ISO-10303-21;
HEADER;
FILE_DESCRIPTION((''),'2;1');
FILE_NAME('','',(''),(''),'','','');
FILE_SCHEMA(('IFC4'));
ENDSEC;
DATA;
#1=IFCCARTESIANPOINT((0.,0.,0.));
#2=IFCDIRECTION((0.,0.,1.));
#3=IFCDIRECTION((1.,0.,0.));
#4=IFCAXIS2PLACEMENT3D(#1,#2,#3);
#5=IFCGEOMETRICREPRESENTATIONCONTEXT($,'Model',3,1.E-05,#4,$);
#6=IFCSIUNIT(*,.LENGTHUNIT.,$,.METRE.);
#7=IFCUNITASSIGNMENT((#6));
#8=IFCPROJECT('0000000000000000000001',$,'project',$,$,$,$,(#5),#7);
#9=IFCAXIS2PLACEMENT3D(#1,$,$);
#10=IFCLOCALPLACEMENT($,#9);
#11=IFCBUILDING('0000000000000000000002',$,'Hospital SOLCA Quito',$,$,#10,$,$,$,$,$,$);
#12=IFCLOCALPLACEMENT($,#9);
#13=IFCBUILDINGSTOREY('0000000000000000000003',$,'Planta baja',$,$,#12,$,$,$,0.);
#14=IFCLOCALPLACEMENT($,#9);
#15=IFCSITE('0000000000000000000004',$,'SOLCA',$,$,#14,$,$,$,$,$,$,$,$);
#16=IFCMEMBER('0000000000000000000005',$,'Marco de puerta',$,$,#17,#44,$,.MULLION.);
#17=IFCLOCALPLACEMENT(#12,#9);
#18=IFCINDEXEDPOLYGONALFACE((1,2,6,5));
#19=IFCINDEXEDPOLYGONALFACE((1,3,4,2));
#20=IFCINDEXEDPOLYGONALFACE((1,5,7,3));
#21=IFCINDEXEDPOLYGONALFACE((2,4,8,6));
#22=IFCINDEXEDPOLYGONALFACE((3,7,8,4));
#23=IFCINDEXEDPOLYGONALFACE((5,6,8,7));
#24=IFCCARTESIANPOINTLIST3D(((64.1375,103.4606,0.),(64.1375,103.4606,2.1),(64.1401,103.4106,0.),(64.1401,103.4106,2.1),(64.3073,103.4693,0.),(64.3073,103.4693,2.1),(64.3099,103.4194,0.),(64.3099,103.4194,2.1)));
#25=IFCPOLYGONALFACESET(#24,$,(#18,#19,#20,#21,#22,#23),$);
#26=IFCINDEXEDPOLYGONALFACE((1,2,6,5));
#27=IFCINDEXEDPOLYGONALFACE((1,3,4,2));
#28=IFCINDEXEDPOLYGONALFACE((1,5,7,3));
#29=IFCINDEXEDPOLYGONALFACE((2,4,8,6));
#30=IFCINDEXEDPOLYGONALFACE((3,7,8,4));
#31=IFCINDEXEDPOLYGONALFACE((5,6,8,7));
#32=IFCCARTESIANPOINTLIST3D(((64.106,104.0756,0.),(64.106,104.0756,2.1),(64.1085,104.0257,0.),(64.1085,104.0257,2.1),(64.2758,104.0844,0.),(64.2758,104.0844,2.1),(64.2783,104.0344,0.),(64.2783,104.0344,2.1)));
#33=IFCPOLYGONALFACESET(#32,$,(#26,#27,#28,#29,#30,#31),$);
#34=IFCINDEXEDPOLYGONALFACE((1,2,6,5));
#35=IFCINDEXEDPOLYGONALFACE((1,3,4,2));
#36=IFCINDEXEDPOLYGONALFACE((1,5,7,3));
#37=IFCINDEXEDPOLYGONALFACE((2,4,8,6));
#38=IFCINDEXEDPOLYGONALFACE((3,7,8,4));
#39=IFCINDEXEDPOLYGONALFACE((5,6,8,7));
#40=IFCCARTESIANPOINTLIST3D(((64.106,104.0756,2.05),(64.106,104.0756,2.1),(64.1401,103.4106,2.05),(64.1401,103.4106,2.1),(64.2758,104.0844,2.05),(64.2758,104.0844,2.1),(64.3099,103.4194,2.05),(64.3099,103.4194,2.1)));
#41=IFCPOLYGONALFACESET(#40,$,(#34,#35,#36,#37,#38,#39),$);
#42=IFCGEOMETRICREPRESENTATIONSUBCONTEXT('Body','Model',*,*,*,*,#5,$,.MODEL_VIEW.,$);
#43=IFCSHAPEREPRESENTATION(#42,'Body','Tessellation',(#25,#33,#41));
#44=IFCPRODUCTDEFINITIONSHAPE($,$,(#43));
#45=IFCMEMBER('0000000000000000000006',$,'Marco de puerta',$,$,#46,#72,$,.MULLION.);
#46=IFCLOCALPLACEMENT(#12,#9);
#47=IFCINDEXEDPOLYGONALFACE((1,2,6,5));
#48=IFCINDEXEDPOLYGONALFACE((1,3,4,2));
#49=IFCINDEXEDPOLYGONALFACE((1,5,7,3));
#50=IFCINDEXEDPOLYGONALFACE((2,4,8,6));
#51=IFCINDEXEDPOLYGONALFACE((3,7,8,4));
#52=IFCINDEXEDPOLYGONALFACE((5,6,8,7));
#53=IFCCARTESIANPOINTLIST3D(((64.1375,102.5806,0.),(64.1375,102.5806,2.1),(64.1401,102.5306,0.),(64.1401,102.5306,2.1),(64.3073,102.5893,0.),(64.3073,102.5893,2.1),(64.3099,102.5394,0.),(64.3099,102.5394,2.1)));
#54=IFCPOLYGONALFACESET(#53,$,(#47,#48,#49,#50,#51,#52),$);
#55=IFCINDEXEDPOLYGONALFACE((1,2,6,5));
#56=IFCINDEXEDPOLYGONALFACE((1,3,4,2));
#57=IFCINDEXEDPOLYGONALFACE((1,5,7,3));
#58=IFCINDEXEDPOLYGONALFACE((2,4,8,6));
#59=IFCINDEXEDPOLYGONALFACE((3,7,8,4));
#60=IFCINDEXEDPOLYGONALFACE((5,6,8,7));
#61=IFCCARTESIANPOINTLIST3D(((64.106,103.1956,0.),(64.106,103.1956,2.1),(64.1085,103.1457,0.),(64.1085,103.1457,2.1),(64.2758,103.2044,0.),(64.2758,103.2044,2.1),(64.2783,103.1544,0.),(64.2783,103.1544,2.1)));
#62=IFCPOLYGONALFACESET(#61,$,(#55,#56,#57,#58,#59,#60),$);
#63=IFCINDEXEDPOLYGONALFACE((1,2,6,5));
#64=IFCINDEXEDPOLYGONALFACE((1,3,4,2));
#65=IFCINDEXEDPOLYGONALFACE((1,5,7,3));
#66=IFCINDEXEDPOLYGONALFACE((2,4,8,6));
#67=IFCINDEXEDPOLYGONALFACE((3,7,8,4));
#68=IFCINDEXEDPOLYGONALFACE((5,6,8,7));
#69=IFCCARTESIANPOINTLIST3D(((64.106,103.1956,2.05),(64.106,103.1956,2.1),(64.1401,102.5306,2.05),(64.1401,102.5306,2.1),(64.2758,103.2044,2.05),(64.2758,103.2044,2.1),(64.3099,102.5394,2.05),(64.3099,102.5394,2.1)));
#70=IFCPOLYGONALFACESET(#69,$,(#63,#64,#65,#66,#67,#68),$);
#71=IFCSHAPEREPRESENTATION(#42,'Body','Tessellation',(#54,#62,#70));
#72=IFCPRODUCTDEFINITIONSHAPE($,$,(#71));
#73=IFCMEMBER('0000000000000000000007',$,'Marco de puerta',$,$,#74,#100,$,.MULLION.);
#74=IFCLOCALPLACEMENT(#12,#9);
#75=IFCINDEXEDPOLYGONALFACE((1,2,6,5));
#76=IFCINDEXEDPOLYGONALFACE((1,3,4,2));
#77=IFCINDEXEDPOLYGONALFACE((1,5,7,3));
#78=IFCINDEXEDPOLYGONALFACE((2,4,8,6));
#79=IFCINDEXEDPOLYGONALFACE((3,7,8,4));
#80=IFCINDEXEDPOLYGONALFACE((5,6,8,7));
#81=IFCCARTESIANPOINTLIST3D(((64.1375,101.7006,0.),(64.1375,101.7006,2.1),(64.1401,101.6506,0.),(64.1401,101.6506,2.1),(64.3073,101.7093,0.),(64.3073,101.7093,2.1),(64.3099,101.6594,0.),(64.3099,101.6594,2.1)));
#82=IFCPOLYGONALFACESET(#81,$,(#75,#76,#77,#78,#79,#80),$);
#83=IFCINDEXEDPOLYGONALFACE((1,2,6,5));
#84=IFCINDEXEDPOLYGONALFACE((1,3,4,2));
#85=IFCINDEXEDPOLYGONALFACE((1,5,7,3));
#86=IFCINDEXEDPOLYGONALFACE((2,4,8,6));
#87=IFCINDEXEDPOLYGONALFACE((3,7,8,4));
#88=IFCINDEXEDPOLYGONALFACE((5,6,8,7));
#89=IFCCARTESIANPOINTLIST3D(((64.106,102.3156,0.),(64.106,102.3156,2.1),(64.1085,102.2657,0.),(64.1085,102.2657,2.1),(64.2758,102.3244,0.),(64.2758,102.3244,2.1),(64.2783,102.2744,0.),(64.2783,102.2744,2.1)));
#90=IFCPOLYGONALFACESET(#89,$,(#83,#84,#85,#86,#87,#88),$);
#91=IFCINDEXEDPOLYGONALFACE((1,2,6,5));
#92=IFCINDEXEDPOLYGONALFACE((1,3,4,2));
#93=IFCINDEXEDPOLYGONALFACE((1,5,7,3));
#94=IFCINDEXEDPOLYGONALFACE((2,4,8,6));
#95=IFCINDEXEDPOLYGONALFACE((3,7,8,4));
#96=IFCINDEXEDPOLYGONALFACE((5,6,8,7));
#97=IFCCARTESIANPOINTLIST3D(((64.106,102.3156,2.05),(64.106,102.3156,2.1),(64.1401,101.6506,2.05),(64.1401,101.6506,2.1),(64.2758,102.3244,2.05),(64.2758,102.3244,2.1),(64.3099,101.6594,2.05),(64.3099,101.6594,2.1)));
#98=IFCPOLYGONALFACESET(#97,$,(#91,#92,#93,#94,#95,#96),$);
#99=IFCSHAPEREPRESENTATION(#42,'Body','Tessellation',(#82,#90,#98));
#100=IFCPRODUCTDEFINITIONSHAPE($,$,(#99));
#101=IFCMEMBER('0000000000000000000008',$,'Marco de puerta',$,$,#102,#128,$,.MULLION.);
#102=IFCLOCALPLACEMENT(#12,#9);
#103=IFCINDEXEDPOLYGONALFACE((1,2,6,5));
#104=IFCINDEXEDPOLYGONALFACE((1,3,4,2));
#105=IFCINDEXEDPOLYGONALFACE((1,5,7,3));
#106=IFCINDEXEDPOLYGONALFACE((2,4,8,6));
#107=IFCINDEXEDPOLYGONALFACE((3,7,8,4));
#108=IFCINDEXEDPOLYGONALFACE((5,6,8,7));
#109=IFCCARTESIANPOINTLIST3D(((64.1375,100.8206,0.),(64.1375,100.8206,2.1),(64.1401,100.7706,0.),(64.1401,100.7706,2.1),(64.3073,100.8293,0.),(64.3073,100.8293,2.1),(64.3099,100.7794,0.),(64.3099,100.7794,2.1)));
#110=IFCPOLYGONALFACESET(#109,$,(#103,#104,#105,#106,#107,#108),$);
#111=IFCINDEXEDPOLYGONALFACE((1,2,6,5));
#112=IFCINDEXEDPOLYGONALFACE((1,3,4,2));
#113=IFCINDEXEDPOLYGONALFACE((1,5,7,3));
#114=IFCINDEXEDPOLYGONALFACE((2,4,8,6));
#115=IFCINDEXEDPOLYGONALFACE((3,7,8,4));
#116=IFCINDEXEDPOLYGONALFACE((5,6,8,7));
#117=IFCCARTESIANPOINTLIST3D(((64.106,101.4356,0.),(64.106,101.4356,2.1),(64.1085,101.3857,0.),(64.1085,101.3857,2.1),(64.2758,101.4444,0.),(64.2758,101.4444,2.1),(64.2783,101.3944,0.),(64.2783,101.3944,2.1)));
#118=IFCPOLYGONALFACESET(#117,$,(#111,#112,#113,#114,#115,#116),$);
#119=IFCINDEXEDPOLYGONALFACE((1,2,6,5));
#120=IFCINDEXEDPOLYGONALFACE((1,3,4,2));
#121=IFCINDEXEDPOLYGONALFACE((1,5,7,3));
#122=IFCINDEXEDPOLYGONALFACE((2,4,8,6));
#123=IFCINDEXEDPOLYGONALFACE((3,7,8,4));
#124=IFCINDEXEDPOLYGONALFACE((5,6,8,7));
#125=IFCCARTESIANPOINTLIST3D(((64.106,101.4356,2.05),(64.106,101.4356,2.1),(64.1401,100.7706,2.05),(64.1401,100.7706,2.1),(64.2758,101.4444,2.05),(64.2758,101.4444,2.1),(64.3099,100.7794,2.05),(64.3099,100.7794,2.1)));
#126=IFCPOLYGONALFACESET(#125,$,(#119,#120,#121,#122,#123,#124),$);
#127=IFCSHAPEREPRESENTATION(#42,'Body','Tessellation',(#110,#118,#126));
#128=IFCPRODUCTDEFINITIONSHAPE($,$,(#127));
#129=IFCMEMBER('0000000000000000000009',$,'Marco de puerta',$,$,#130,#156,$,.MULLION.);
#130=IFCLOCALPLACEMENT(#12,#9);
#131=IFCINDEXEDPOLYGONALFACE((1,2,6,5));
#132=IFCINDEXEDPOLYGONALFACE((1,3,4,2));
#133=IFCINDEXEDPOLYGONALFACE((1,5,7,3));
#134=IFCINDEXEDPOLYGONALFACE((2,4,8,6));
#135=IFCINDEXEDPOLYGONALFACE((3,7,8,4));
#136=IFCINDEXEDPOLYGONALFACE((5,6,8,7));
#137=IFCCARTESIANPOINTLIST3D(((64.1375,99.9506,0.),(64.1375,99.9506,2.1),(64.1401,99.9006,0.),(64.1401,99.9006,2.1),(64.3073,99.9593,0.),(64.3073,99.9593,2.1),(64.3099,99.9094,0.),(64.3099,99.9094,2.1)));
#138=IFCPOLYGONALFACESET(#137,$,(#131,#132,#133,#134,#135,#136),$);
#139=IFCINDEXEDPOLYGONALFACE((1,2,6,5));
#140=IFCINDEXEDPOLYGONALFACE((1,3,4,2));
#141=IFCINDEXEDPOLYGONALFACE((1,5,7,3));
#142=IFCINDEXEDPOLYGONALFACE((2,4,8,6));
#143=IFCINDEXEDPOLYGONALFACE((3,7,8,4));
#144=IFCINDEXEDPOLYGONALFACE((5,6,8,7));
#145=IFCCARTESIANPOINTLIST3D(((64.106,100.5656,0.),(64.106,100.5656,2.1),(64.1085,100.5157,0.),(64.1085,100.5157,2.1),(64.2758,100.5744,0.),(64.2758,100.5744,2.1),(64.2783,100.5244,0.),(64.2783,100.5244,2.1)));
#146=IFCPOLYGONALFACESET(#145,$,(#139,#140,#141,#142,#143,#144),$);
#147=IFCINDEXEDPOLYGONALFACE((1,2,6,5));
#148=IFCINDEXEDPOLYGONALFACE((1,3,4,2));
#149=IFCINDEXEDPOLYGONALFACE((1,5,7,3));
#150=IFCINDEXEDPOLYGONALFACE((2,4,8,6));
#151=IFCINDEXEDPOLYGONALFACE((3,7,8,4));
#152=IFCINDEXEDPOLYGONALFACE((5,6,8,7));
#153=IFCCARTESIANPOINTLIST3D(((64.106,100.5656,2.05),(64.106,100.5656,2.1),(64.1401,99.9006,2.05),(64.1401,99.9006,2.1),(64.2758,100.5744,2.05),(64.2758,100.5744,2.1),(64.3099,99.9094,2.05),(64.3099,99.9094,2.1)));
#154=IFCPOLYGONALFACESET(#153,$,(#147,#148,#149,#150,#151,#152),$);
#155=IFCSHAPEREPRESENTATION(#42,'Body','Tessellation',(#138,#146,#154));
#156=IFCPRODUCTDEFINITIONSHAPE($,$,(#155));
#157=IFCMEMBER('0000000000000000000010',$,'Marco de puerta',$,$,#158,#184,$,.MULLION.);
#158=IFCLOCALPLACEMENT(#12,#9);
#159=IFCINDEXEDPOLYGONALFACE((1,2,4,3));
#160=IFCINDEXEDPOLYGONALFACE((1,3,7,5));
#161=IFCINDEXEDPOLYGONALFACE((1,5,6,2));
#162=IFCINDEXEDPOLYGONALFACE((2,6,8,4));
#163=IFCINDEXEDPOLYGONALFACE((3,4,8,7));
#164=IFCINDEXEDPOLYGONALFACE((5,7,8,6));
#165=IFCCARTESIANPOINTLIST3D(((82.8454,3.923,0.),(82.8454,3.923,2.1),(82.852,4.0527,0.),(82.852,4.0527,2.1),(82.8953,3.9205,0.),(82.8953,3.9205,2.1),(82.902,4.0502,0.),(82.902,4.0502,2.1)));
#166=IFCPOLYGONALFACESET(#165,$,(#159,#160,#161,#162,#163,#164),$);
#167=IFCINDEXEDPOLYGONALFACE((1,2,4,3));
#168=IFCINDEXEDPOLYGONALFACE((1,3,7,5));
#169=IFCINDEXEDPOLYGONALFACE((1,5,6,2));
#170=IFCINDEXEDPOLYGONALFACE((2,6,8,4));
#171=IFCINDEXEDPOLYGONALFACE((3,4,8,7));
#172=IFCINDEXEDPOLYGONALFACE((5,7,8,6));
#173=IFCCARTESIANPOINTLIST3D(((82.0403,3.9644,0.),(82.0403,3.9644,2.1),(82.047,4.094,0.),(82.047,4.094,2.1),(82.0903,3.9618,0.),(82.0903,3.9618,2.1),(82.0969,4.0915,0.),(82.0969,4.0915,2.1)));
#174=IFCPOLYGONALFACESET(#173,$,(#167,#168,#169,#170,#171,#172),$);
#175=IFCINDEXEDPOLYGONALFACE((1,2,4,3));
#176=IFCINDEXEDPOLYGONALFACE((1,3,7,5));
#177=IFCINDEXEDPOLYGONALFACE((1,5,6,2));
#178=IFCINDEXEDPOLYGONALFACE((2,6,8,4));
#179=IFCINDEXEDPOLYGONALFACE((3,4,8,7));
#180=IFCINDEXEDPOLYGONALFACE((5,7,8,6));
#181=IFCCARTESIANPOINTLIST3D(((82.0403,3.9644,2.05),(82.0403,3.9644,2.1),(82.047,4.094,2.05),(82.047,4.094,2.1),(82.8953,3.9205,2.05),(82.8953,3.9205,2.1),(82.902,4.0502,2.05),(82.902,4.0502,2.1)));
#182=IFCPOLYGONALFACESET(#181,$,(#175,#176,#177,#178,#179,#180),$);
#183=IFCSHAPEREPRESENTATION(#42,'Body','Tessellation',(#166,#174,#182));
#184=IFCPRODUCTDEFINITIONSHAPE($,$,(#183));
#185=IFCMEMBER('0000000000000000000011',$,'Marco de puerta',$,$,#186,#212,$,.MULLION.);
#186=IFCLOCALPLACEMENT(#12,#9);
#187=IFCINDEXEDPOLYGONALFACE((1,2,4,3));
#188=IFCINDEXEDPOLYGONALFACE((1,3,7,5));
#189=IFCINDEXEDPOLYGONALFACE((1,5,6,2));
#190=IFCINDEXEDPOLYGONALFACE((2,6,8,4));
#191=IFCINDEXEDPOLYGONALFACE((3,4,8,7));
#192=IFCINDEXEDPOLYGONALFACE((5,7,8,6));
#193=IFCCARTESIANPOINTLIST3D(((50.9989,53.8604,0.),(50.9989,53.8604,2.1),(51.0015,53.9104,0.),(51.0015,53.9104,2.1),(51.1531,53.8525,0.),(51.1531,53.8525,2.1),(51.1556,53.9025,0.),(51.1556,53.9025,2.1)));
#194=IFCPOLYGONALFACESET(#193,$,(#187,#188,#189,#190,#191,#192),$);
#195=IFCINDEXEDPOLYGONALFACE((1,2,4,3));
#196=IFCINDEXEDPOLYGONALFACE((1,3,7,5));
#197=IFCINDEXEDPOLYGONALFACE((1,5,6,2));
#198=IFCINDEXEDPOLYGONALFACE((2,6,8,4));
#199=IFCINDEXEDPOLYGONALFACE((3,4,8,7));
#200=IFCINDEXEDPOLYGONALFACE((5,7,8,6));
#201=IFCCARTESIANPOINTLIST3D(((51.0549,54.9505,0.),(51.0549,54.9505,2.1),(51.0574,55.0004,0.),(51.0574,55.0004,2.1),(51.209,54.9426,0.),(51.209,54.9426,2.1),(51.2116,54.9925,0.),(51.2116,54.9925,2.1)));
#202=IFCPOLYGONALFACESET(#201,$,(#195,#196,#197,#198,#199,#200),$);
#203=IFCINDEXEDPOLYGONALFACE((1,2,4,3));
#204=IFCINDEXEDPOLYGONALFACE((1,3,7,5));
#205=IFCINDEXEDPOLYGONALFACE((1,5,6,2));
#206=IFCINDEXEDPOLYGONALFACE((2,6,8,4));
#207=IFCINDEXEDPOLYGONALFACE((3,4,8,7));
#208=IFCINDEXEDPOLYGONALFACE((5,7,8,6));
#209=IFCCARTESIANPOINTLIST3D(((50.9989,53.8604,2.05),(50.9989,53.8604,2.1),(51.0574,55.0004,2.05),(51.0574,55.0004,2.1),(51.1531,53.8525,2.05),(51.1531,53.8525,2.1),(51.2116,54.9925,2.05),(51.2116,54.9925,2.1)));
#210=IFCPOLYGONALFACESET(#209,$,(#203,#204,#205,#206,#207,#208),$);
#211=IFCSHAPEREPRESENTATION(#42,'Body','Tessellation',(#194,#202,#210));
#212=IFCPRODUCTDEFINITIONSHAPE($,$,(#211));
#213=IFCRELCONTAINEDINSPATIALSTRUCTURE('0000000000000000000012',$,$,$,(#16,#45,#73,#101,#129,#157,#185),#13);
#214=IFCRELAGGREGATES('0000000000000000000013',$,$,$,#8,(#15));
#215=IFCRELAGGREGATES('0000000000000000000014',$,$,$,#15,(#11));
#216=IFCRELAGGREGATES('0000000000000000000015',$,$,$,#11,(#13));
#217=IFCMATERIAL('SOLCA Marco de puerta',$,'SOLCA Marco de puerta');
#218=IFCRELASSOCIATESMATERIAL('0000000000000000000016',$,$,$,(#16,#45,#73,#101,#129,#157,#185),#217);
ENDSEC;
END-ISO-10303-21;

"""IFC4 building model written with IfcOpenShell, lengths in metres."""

from ifc_helpers import new_model, si_unit, frame, origin, origin_with_axes, place, context, subcontext, project, spatial, polyline, outline, extrude, material, element, save


model = new_model("IFC4")

# Units and contexts
model_context = context("Model", 3, precision=1e-05, world=origin_with_axes())
body_context = subcontext(model_context, "Body", "Model", "MODEL_VIEW")
ifc_project = project(units=[si_unit("LENGTHUNIT", "METRE")], contexts=[model_context])

# Site, building, storey
site_placement = place(None, origin())
site = spatial("IfcSite", under=ifc_project, at=site_placement, Name="SOLCA")
building_placement = place(None, origin())
building = spatial("IfcBuilding", under=site, at=building_placement, Name="Hospital SOLCA Quito")
storey_placement = place(None, origin())
storey = spatial("IfcBuildingStorey", under=building, at=storey_placement, Name="Planta baja", Elevation=0.0)

# Members
ifc_material_1 = material(Name="SOLCA Marco de puerta", Category="SOLCA Marco de puerta")
member_1_placement = place(storey_placement, origin_with_axes())
element("IfcMember", 1, at=member_1_placement, inside=storey, material=ifc_material_1, Name="Marco de puerta", PredefinedType="MULLION", context=body_context, shape_type="SweptSolid", body=[
    extrude(outline(polyline([(64.3099, 103.4194), (64.3073, 103.4693), (64.1375, 103.4606), (64.1401, 103.4106), (64.3099, 103.4194)])), origin_with_axes(), (0.0, 0.0, 1.0), 2.1),
    extrude(outline(polyline([(64.2783, 104.0344), (64.2758, 104.0844), (64.106, 104.0756), (64.1085, 104.0257), (64.2783, 104.0344)])), origin_with_axes(), (0.0, 0.0, 1.0), 2.1),
    extrude(outline(polyline([(64.3099, 103.4194), (64.2758, 104.0844), (64.106, 104.0756), (64.1401, 103.4106), (64.3099, 103.4194)])), frame((0.0, 0.0, 2.05), z_axis=(0.0, 0.0, 1.0), x_axis=(1.0, 0.0, 0.0)), (0.0, 0.0, 1.0), 0.05),
])
member_2_placement = place(storey_placement, origin_with_axes())
element("IfcMember", 2, at=member_2_placement, inside=storey, material=ifc_material_1, Name="Marco de puerta", PredefinedType="MULLION", context=body_context, shape_type="SweptSolid", body=[
    extrude(outline(polyline([(64.3099, 102.5394), (64.3073, 102.5893), (64.1375, 102.5806), (64.1401, 102.5306), (64.3099, 102.5394)])), origin_with_axes(), (0.0, 0.0, 1.0), 2.1),
    extrude(outline(polyline([(64.2783, 103.1544), (64.2758, 103.2044), (64.106, 103.1956), (64.1085, 103.1457), (64.2783, 103.1544)])), origin_with_axes(), (0.0, 0.0, 1.0), 2.1),
    extrude(outline(polyline([(64.3099, 102.5394), (64.2758, 103.2044), (64.106, 103.1956), (64.1401, 102.5306), (64.3099, 102.5394)])), frame((0.0, 0.0, 2.05), z_axis=(0.0, 0.0, 1.0), x_axis=(1.0, 0.0, 0.0)), (0.0, 0.0, 1.0), 0.05),
])
member_3_placement = place(storey_placement, origin_with_axes())
element("IfcMember", 3, at=member_3_placement, inside=storey, material=ifc_material_1, Name="Marco de puerta", PredefinedType="MULLION", context=body_context, shape_type="SweptSolid", body=[
    extrude(outline(polyline([(64.3099, 101.6594), (64.3073, 101.7093), (64.1375, 101.7006), (64.1401, 101.6506), (64.3099, 101.6594)])), origin_with_axes(), (0.0, 0.0, 1.0), 2.1),
    extrude(outline(polyline([(64.2783, 102.2744), (64.2758, 102.3244), (64.106, 102.3156), (64.1085, 102.2657), (64.2783, 102.2744)])), origin_with_axes(), (0.0, 0.0, 1.0), 2.1),
    extrude(outline(polyline([(64.3099, 101.6594), (64.2758, 102.3244), (64.106, 102.3156), (64.1401, 101.6506), (64.3099, 101.6594)])), frame((0.0, 0.0, 2.05), z_axis=(0.0, 0.0, 1.0), x_axis=(1.0, 0.0, 0.0)), (0.0, 0.0, 1.0), 0.05),
])
member_4_placement = place(storey_placement, origin_with_axes())
element("IfcMember", 4, at=member_4_placement, inside=storey, material=ifc_material_1, Name="Marco de puerta", PredefinedType="MULLION", context=body_context, shape_type="SweptSolid", body=[
    extrude(outline(polyline([(64.3099, 100.7794), (64.3073, 100.8293), (64.1375, 100.8206), (64.1401, 100.7706), (64.3099, 100.7794)])), origin_with_axes(), (0.0, 0.0, 1.0), 2.1),
    extrude(outline(polyline([(64.2783, 101.3944), (64.2758, 101.4444), (64.106, 101.4356), (64.1085, 101.3857), (64.2783, 101.3944)])), origin_with_axes(), (0.0, 0.0, 1.0), 2.1),
    extrude(outline(polyline([(64.3099, 100.7794), (64.2758, 101.4444), (64.106, 101.4356), (64.1401, 100.7706), (64.3099, 100.7794)])), frame((0.0, 0.0, 2.05), z_axis=(0.0, 0.0, 1.0), x_axis=(1.0, 0.0, 0.0)), (0.0, 0.0, 1.0), 0.05),
])
member_5_placement = place(storey_placement, origin_with_axes())
element("IfcMember", 5, at=member_5_placement, inside=storey, material=ifc_material_1, Name="Marco de puerta", PredefinedType="MULLION", context=body_context, shape_type="SweptSolid", body=[
    extrude(outline(polyline([(64.3099, 99.9094), (64.3073, 99.9593), (64.1375, 99.9506), (64.1401, 99.9006), (64.3099, 99.9094)])), origin_with_axes(), (0.0, 0.0, 1.0), 2.1),
    extrude(outline(polyline([(64.2783, 100.5244), (64.2758, 100.5744), (64.106, 100.5656), (64.1085, 100.5157), (64.2783, 100.5244)])), origin_with_axes(), (0.0, 0.0, 1.0), 2.1),
    extrude(outline(polyline([(64.3099, 99.9094), (64.2758, 100.5744), (64.106, 100.5656), (64.1401, 99.9006), (64.3099, 99.9094)])), frame((0.0, 0.0, 2.05), z_axis=(0.0, 0.0, 1.0), x_axis=(1.0, 0.0, 0.0)), (0.0, 0.0, 1.0), 0.05),
])
member_6_placement = place(storey_placement, origin_with_axes())
element("IfcMember", 6, at=member_6_placement, inside=storey, material=ifc_material_1, Name="Marco de puerta", PredefinedType="MULLION", context=body_context, shape_type="SweptSolid", body=[
    extrude(outline(polyline([(82.902, 4.0502), (82.852, 4.0527), (82.8454, 3.923), (82.8953, 3.9205), (82.902, 4.0502)])), origin_with_axes(), (0.0, 0.0, 1.0), 2.1),
    extrude(outline(polyline([(82.0969, 4.0915), (82.047, 4.094), (82.0403, 3.9644), (82.0903, 3.9618), (82.0969, 4.0915)])), origin_with_axes(), (0.0, 0.0, 1.0), 2.1),
    extrude(outline(polyline([(82.902, 4.0502), (82.047, 4.094), (82.0403, 3.9644), (82.8953, 3.9205), (82.902, 4.0502)])), frame((0.0, 0.0, 2.05), z_axis=(0.0, 0.0, 1.0), x_axis=(1.0, 0.0, 0.0)), (0.0, 0.0, 1.0), 0.05),
])
member_7_placement = place(storey_placement, origin_with_axes())
element("IfcMember", 7, at=member_7_placement, inside=storey, material=ifc_material_1, Name="Marco de puerta", PredefinedType="MULLION", context=body_context, shape_type="SweptSolid", body=[
    extrude(outline(polyline([(51.1531, 53.8525), (51.1556, 53.9025), (51.0015, 53.9104), (50.9989, 53.8604), (51.1531, 53.8525)])), origin_with_axes(), (0.0, 0.0, 1.0), 2.1),
    extrude(outline(polyline([(51.209, 54.9426), (51.2116, 54.9925), (51.0574, 55.0004), (51.0549, 54.9505), (51.209, 54.9426)])), origin_with_axes(), (0.0, 0.0, 1.0), 2.1),
    extrude(outline(polyline([(51.1531, 53.8525), (51.2116, 54.9925), (51.0574, 55.0004), (50.9989, 53.8604), (51.1531, 53.8525)])), frame((0.0, 0.0, 2.05), z_axis=(0.0, 0.0, 1.0), x_axis=(1.0, 0.0, 0.0)), (0.0, 0.0, 1.0), 0.05),
])

save(model, "model.ifc")
